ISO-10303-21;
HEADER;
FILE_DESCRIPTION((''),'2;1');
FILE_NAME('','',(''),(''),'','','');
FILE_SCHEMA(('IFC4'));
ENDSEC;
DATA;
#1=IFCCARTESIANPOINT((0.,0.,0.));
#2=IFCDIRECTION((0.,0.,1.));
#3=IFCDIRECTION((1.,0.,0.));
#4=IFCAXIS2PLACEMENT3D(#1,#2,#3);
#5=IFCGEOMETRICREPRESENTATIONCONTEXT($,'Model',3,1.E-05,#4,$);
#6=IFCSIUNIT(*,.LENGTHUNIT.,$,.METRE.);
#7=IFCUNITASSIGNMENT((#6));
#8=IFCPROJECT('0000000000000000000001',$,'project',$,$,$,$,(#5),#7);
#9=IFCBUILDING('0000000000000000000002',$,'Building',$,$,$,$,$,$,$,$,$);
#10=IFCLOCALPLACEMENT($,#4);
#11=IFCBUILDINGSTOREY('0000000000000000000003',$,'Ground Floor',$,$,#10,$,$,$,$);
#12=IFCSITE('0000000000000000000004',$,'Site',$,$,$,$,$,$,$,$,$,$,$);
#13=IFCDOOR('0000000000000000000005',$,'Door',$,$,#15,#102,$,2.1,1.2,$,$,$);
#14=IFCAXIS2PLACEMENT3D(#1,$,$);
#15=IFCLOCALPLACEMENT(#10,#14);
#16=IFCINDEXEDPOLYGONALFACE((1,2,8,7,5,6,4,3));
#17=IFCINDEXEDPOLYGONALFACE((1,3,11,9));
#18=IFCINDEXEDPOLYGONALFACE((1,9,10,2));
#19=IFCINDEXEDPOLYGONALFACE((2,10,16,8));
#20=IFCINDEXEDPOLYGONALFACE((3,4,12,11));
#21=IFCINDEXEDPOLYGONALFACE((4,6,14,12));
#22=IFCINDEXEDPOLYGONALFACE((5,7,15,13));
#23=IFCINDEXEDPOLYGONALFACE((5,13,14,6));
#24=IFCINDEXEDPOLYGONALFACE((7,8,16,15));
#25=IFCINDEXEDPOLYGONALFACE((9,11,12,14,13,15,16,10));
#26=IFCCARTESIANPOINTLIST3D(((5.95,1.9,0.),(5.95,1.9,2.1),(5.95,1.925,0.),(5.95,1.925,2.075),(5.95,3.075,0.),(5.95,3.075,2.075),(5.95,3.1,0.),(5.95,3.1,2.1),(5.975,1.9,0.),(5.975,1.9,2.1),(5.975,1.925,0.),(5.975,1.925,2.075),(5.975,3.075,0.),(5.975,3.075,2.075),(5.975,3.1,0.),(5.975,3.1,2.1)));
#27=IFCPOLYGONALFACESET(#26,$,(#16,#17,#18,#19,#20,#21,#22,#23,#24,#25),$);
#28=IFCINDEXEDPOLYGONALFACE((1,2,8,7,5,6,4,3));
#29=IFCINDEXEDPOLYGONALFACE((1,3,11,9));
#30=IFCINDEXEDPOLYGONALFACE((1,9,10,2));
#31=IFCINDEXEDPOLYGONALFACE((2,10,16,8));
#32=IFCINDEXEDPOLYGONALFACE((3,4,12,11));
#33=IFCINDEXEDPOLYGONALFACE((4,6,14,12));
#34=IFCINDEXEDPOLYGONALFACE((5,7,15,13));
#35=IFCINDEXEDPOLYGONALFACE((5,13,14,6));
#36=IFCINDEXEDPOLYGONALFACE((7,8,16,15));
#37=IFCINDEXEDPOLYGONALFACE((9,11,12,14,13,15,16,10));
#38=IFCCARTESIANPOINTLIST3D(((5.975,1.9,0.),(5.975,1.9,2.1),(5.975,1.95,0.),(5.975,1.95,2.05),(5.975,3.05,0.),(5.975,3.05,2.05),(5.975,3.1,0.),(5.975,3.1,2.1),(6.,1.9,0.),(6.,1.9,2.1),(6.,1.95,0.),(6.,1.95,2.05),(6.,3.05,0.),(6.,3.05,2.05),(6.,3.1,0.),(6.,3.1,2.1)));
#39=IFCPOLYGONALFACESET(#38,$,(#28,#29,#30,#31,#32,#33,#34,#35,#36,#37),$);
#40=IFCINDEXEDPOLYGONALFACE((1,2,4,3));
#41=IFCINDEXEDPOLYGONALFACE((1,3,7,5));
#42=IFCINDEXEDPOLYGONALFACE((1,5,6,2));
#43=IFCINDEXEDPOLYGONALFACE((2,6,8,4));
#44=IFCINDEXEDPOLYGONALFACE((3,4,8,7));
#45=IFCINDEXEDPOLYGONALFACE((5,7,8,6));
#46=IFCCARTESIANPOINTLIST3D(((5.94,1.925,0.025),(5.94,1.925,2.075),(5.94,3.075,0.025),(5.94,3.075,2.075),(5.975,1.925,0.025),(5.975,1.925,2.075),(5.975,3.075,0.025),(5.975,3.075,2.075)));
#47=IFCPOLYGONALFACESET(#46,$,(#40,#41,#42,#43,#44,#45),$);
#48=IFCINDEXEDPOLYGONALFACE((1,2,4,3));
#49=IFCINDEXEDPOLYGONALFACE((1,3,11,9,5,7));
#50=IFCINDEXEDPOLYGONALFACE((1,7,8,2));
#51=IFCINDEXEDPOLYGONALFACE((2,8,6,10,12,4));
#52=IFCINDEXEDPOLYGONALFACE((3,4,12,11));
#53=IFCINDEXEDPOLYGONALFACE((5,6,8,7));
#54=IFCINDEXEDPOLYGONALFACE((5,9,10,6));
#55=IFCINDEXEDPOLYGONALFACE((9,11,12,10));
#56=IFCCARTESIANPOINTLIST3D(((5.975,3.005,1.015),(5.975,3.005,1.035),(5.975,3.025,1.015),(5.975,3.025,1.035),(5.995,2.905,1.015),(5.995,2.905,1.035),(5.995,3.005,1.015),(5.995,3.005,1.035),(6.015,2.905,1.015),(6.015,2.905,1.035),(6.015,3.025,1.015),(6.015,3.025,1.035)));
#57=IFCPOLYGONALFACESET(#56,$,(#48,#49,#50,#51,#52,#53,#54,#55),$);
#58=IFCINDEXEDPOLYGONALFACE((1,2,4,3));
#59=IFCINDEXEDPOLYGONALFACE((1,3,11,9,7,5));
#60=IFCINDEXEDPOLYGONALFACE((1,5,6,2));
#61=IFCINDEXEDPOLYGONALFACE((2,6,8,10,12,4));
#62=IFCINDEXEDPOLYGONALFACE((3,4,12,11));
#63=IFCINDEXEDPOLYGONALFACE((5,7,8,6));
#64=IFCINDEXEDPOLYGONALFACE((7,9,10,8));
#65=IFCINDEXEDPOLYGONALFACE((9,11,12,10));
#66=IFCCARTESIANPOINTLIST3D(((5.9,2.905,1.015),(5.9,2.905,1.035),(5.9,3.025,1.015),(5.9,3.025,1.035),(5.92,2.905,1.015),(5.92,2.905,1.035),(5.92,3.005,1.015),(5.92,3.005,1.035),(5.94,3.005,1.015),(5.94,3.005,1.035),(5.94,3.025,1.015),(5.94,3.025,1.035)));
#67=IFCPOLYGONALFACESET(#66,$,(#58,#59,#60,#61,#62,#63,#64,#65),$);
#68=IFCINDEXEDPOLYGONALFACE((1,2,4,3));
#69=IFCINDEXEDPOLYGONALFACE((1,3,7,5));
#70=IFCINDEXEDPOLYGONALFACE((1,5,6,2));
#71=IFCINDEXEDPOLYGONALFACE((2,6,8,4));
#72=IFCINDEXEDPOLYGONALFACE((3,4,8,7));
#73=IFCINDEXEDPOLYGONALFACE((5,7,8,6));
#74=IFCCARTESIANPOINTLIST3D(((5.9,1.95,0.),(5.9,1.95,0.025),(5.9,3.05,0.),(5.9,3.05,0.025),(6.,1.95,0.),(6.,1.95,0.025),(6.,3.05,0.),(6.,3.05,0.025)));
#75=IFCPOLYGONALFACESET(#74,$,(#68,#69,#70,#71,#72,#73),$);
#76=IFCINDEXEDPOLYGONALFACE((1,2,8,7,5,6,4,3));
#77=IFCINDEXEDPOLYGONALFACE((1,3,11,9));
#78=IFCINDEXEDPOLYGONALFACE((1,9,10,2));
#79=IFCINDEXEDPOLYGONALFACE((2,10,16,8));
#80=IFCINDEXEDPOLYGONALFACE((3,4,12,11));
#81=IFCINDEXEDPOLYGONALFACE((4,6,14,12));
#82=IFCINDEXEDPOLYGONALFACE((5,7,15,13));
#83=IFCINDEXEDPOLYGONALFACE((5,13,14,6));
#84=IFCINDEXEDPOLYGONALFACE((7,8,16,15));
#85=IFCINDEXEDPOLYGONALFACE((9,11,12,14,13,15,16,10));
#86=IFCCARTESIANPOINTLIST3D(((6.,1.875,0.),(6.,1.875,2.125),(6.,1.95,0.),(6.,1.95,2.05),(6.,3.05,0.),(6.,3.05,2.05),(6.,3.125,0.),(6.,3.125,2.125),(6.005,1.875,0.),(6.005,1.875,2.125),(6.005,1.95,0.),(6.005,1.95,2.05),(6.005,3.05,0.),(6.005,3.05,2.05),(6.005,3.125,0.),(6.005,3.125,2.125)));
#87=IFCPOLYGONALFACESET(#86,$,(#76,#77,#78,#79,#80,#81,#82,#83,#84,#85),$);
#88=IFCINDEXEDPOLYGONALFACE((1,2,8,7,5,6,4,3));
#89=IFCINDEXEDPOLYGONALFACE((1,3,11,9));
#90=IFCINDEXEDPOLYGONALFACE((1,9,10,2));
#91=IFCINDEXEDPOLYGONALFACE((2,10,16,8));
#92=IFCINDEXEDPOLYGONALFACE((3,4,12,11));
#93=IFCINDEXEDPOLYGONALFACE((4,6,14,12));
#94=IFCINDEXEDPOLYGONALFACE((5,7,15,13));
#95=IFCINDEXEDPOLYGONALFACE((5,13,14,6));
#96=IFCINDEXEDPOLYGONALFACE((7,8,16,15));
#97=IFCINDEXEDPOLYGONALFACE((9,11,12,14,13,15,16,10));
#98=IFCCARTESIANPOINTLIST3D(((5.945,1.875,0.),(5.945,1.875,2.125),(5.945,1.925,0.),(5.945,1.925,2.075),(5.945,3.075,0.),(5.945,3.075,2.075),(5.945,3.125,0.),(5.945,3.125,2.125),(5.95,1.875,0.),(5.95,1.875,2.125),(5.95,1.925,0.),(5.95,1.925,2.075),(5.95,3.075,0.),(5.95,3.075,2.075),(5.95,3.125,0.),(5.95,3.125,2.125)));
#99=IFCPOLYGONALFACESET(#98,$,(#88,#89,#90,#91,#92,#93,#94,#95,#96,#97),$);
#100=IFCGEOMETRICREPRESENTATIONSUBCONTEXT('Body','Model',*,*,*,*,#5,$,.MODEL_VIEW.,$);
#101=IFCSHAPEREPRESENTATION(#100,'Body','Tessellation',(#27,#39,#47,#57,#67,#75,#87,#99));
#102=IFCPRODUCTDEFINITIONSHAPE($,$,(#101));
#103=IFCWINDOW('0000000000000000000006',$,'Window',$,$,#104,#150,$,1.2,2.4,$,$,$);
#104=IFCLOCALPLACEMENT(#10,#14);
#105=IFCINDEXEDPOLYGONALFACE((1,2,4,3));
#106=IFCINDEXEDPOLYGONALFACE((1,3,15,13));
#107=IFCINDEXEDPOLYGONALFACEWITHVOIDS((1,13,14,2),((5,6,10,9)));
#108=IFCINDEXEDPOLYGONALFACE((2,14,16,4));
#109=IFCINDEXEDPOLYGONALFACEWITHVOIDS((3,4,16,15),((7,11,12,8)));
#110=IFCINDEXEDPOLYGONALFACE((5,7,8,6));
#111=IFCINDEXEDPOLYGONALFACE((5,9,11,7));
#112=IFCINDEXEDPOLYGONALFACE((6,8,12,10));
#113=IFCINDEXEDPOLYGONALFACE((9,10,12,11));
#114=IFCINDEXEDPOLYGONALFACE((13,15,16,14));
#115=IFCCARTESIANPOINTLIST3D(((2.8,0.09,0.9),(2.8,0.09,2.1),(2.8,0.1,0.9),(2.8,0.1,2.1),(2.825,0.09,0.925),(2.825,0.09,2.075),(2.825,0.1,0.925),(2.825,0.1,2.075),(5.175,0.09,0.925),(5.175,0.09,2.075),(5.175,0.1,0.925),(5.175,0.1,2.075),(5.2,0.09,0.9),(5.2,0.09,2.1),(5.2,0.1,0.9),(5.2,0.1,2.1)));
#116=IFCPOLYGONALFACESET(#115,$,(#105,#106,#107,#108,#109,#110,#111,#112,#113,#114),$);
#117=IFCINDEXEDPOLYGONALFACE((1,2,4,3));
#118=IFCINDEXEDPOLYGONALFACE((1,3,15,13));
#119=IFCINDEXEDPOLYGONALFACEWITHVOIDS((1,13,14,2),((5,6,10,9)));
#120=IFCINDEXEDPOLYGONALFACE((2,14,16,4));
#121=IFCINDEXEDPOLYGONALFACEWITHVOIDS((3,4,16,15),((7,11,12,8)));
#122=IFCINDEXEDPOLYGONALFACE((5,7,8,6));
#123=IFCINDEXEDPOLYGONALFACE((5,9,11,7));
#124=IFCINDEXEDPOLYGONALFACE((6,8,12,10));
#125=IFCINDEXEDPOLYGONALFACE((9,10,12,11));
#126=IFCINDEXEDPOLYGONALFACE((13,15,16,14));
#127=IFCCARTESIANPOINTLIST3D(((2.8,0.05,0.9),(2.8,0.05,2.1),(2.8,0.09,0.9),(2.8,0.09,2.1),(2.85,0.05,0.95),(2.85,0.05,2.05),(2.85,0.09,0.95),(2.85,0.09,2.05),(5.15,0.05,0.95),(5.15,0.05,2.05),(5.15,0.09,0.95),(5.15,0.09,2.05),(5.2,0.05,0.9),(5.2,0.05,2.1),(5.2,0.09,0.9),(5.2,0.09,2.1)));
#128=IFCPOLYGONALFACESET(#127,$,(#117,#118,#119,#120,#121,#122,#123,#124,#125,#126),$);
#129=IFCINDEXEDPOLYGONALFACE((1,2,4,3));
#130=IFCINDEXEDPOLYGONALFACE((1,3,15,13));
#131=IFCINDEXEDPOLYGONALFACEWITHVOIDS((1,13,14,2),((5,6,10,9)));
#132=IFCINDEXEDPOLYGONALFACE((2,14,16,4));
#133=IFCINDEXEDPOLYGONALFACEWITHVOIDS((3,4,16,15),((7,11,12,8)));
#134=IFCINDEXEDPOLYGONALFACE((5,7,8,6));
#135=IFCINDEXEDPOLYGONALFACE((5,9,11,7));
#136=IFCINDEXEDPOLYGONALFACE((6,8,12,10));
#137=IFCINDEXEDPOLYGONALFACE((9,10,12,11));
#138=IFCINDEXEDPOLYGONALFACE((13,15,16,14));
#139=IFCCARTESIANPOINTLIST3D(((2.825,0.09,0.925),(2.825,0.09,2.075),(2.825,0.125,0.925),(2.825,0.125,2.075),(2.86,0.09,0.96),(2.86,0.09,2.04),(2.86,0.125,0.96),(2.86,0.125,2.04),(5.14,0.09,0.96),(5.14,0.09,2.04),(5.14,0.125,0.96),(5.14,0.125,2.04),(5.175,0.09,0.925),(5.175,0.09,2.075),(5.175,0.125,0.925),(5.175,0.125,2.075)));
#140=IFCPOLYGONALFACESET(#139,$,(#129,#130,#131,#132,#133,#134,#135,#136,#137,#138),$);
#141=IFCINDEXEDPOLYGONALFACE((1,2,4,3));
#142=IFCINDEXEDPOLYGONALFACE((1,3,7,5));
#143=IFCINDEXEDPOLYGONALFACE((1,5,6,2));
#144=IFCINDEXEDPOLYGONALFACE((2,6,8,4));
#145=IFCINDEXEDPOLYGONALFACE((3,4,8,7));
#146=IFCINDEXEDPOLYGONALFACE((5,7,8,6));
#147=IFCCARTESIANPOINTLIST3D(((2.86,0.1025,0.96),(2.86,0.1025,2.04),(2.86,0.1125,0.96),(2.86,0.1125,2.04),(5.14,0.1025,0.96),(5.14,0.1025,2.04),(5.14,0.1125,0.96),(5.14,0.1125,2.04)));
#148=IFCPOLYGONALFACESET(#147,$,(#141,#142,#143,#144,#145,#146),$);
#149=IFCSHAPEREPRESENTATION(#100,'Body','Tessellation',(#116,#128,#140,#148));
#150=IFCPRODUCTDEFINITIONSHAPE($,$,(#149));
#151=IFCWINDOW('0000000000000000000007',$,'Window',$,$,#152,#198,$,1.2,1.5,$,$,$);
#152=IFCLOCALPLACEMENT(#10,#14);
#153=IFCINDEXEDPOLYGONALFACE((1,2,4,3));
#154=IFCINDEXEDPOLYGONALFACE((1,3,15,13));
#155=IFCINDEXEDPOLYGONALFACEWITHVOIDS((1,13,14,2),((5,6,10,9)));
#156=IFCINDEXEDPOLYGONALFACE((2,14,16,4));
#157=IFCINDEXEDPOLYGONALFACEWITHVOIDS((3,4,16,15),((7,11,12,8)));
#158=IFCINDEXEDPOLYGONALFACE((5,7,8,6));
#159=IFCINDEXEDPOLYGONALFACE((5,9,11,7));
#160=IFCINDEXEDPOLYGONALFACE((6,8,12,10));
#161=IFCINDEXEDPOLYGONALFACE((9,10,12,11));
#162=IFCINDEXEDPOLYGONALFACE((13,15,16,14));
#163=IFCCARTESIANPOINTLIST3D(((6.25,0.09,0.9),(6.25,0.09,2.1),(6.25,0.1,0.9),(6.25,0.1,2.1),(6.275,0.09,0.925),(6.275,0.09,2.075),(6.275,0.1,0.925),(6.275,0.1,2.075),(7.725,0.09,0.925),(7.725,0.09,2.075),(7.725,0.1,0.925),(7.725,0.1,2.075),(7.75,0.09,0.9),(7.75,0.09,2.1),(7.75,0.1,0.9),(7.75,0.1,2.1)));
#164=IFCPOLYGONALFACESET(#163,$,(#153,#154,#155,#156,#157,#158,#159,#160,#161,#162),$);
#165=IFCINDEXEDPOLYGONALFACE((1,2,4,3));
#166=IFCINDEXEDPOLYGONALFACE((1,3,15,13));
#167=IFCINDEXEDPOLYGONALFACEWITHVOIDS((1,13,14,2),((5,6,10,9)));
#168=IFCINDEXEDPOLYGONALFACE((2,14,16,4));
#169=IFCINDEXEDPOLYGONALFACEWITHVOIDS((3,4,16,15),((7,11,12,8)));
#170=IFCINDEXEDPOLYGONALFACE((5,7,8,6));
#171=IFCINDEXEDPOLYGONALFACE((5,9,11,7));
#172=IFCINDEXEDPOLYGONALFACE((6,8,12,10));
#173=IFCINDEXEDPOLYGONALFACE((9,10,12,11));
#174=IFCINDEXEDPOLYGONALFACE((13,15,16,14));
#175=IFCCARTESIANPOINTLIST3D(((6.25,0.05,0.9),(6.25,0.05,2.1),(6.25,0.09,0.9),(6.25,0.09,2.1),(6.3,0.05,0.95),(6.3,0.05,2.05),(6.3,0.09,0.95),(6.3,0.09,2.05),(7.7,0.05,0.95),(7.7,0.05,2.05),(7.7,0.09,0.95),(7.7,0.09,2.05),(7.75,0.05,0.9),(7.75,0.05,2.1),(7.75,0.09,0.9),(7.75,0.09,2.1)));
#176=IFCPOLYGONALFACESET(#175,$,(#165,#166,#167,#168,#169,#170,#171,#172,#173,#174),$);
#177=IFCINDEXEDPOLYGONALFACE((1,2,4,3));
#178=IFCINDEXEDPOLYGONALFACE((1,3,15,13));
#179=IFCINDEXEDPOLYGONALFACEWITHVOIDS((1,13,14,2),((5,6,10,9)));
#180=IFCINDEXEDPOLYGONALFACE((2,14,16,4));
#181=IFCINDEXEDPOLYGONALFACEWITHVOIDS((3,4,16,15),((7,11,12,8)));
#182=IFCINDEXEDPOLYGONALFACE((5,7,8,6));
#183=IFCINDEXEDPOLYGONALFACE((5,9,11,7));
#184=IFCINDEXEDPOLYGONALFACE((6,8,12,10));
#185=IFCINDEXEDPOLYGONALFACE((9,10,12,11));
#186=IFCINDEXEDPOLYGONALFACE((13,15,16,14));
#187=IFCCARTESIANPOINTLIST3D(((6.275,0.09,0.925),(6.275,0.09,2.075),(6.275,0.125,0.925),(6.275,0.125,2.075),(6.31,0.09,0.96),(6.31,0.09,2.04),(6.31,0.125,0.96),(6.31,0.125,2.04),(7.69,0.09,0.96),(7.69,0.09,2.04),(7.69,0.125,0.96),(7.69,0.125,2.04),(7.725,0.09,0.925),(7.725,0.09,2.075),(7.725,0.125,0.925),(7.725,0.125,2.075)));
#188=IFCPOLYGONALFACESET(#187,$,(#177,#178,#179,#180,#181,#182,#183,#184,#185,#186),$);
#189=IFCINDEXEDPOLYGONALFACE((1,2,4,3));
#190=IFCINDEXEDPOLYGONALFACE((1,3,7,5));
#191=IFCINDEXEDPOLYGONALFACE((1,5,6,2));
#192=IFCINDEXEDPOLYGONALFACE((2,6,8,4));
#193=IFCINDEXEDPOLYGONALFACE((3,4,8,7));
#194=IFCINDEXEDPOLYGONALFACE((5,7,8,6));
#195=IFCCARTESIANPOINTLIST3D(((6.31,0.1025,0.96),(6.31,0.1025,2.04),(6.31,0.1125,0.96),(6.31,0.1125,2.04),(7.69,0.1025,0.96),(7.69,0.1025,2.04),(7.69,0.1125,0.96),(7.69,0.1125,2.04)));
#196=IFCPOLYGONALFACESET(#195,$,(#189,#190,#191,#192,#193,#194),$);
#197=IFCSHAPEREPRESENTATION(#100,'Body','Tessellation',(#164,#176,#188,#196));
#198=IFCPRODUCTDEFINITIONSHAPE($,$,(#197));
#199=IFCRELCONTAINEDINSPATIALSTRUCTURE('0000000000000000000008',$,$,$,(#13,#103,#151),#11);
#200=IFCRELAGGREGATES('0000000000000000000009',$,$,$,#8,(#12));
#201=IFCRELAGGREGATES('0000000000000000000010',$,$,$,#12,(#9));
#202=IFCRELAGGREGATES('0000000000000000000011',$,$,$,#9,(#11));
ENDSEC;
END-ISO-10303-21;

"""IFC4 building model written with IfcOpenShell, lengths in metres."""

from ifc_helpers import new_model, si_unit, frame, origin_with_axes, place, context, subcontext, project, spatial, line, indexed_curve, outline, extrude, element, save


model = new_model("IFC4")

# Units and contexts
model_context = context("Model", 3, precision=1e-05, world=origin_with_axes())
body_context = subcontext(model_context, "Body", "Model", "MODEL_VIEW")
ifc_project = project(units=[si_unit("LENGTHUNIT", "METRE")], contexts=[model_context])

# Site, building, storey
site = spatial("IfcSite", under=ifc_project, Name="Site")
building = spatial("IfcBuilding", under=site, Name="Building")
storey_placement = place(None, origin_with_axes())
storey = spatial("IfcBuildingStorey", under=building, at=storey_placement, Name="Ground Floor")

# Door
door_1_placement = place(storey_placement, frame((6.0, 1.9, 0.0), z_axis=(0.0, 0.0, 1.0), x_axis=(0.0, 1.0, 0.0)))
element("IfcDoor", 1, at=door_1_placement, inside=storey, Name="Door", OverallHeight=2.1, OverallWidth=1.2, context=body_context, shape_type="SweptSolid", body=[
    extrude(outline(indexed_curve([(0.0, 0.0), (0.0, 2.1), (1.2, 2.1), (1.2, 0.0), (1.175, 0.0), (1.175, 2.075), (0.025, 2.075), (0.025, 0.0)], segments=[line(1, 2, 3, 4, 5, 6, 7, 8, 1)])), frame((0.0, 0.025, 0.0), z_axis=(0.0, -1.0, 0.0), x_axis=(1.0, 0.0, 0.0)), (0.0, 0.0, -1.0), 0.025),
    extrude(outline(indexed_curve([(0.0, 0.0), (0.0, 2.1), (1.2, 2.1), (1.2, 0.0), (1.15, 0.0), (1.15, 2.05), (0.05, 2.05), (0.05, 0.0)], segments=[line(1, 2, 3, 4, 5, 6, 7, 8, 1)])), frame((0.0, 0.0, 0.0), z_axis=(0.0, -1.0, 0.0), x_axis=(1.0, 0.0, 0.0)), (0.0, 0.0, -1.0), 0.025),
    extrude(outline(indexed_curve([(0.0, 0.0), (1.15, 0.0), (1.15, 0.035), (0.0, 0.035)], segments=[line(1, 2, 3, 4, 1)])), frame((0.025, 0.025, 0.025), z_axis=(0.0, 0.0, 1.0), x_axis=(1.0, 0.0, 0.0)), (0.0, 0.0, 1.0), 2.05),
    extrude(outline(indexed_curve([(0.0, 0.0), (0.0, -0.04), (-0.12, -0.04), (-0.12, -0.02), (-0.02, -0.02), (-0.02, 0.0)], segments=[line(1, 2, 3, 4, 5, 6, 1)])), frame((1.125, 0.025, 1.015), z_axis=(0.0, 0.0, 1.0), x_axis=(1.0, 0.0, 0.0)), (0.0, 0.0, 1.0), 0.02),
    extrude(outline(indexed_curve([(0.0, 0.0), (0.0, 0.04), (-0.12, 0.04), (-0.12, 0.02), (-0.02, 0.02), (-0.02, 0.0)], segments=[line(1, 2, 3, 4, 5, 6, 1)])), frame((1.125, 0.06, 1.015), z_axis=(0.0, 0.0, 1.0), x_axis=(1.0, 0.0, 0.0)), (0.0, 0.0, 1.0), 0.02),
    extrude(outline(indexed_curve([(0.0, 0.0), (1.1, 0.0), (1.1, 0.1), (0.0, 0.1)], segments=[line(1, 2, 3, 4, 1)])), frame((0.05, 0.0, 0.0), z_axis=(0.0, 0.0, 1.0), x_axis=(1.0, 0.0, 0.0)), (0.0, 0.0, 1.0), 0.025),
    extrude(outline(indexed_curve([(0.0, 0.0), (0.0, 2.125), (1.25, 2.125), (1.25, 0.0), (1.175, 0.0), (1.175, 2.05), (0.075, 2.05), (0.075, 0.0)], segments=[line(1, 2, 3, 4, 5, 6, 7, 8, 1)])), frame((-0.025, -0.005, 0.0), z_axis=(0.0, -1.0, 0.0), x_axis=(1.0, 0.0, 0.0)), (0.0, 0.0, -1.0), 0.005),
    extrude(outline(indexed_curve([(0.0, 0.0), (0.0, 2.125), (1.25, 2.125), (1.25, 0.0), (1.2, 0.0), (1.2, 2.075), (0.05, 2.075), (0.05, 0.0)], segments=[line(1, 2, 3, 4, 5, 6, 7, 8, 1)])), frame((-0.025, 0.05, 0.0), z_axis=(0.0, -1.0, 0.0), x_axis=(1.0, 0.0, 0.0)), (0.0, 0.0, -1.0), 0.005),
])

# Windows
window_1_placement = place(storey_placement, frame((2.8, 0.0, 0.9), z_axis=(0.0, 0.0, 1.0), x_axis=(1.0, 0.0, 0.0)))
element("IfcWindow", 2, at=window_1_placement, inside=storey, Name="Window", OverallHeight=1.2, OverallWidth=2.4, context=body_context, shape_type="SweptSolid", body=[
    extrude(outline(indexed_curve([(0.0, 0.0), (2.4, 0.0), (2.4, 1.2), (0.0, 1.2)], segments=[line(1, 2, 3, 4, 1)]), holes=[indexed_curve([(0.025, 0.025), (2.375, 0.025), (2.375, 1.175), (0.025, 1.175)], segments=[line(1, 2, 3, 4, 1)])]), frame((0.0, 0.09, 0.0), z_axis=(0.0, -1.0, 0.0), x_axis=(1.0, 0.0, 0.0)), (0.0, 0.0, -1.0), 0.01),
    extrude(outline(indexed_curve([(0.0, 0.0), (2.4, 0.0), (2.4, 1.2), (0.0, 1.2)], segments=[line(1, 2, 3, 4, 1)]), holes=[indexed_curve([(0.05, 0.05), (2.35, 0.05), (2.35, 1.15), (0.05, 1.15)], segments=[line(1, 2, 3, 4, 1)])]), frame((0.0, 0.05, 0.0), z_axis=(0.0, -1.0, 0.0), x_axis=(1.0, 0.0, 0.0)), (0.0, 0.0, -1.0), 0.04),
    extrude(outline(indexed_curve([(0.0, 0.0), (2.35, 0.0), (2.35, 1.15), (0.0, 1.15)], segments=[line(1, 2, 3, 4, 1)]), holes=[indexed_curve([(0.035, 0.035), (2.315, 0.035), (2.315, 1.115), (0.035, 1.115)], segments=[line(1, 2, 3, 4, 1)])]), frame((0.025, 0.09, 0.025), z_axis=(0.0, -1.0, 0.0), x_axis=(1.0, 0.0, 0.0)), (0.0, 0.0, -1.0), 0.035),
    extrude(outline(indexed_curve([(0.035, 0.035), (2.315, 0.035), (2.315, 1.115), (0.035, 1.115)], segments=[line(1, 2, 3, 4, 1)])), frame((0.025, 0.1025, 0.025), z_axis=(0.0, -1.0, 0.0), x_axis=(1.0, 0.0, 0.0)), (0.0, 0.0, -1.0), 0.01),
])
for number, where, z_axis, x_axis, name in (
    (3, (6.25, 0.0, 0.9), (0.0, 0.0, 1.0), (1.0, 0.0, 0.0), "Window"),
):
    element("IfcWindow", number, at=place(storey_placement, frame(where, z_axis=z_axis, x_axis=x_axis)), inside=storey, Name=name, OverallHeight=1.2, OverallWidth=1.5, context=body_context, shape_type="SweptSolid", body=[
        extrude(outline(indexed_curve([(0.0, 0.0), (1.5, 0.0), (1.5, 1.2), (0.0, 1.2)], segments=[line(1, 2, 3, 4, 1)]), holes=[indexed_curve([(0.025, 0.025), (1.475, 0.025), (1.475, 1.175), (0.025, 1.175)], segments=[line(1, 2, 3, 4, 1)])]), frame((0.0, 0.09, 0.0), z_axis=(0.0, -1.0, 0.0), x_axis=(1.0, 0.0, 0.0)), (0.0, 0.0, -1.0), 0.01),
        extrude(outline(indexed_curve([(0.0, 0.0), (1.5, 0.0), (1.5, 1.2), (0.0, 1.2)], segments=[line(1, 2, 3, 4, 1)]), holes=[indexed_curve([(0.05, 0.05), (1.45, 0.05), (1.45, 1.15), (0.05, 1.15)], segments=[line(1, 2, 3, 4, 1)])]), frame((0.0, 0.05, 0.0), z_axis=(0.0, -1.0, 0.0), x_axis=(1.0, 0.0, 0.0)), (0.0, 0.0, -1.0), 0.04),
        extrude(outline(indexed_curve([(0.0, 0.0), (1.45, 0.0), (1.45, 1.15), (0.0, 1.15)], segments=[line(1, 2, 3, 4, 1)]), holes=[indexed_curve([(0.035, 0.035), (1.415, 0.035), (1.415, 1.115), (0.035, 1.115)], segments=[line(1, 2, 3, 4, 1)])]), frame((0.025, 0.09, 0.025), z_axis=(0.0, -1.0, 0.0), x_axis=(1.0, 0.0, 0.0)), (0.0, 0.0, -1.0), 0.035),
        extrude(outline(indexed_curve([(0.035, 0.035), (1.415, 0.035), (1.415, 1.115), (0.035, 1.115)], segments=[line(1, 2, 3, 4, 1)])), frame((0.025, 0.1025, 0.025), z_axis=(0.0, -1.0, 0.0), x_axis=(1.0, 0.0, 0.0)), (0.0, 0.0, -1.0), 0.01),
    ])

save(model, "model.ifc")
